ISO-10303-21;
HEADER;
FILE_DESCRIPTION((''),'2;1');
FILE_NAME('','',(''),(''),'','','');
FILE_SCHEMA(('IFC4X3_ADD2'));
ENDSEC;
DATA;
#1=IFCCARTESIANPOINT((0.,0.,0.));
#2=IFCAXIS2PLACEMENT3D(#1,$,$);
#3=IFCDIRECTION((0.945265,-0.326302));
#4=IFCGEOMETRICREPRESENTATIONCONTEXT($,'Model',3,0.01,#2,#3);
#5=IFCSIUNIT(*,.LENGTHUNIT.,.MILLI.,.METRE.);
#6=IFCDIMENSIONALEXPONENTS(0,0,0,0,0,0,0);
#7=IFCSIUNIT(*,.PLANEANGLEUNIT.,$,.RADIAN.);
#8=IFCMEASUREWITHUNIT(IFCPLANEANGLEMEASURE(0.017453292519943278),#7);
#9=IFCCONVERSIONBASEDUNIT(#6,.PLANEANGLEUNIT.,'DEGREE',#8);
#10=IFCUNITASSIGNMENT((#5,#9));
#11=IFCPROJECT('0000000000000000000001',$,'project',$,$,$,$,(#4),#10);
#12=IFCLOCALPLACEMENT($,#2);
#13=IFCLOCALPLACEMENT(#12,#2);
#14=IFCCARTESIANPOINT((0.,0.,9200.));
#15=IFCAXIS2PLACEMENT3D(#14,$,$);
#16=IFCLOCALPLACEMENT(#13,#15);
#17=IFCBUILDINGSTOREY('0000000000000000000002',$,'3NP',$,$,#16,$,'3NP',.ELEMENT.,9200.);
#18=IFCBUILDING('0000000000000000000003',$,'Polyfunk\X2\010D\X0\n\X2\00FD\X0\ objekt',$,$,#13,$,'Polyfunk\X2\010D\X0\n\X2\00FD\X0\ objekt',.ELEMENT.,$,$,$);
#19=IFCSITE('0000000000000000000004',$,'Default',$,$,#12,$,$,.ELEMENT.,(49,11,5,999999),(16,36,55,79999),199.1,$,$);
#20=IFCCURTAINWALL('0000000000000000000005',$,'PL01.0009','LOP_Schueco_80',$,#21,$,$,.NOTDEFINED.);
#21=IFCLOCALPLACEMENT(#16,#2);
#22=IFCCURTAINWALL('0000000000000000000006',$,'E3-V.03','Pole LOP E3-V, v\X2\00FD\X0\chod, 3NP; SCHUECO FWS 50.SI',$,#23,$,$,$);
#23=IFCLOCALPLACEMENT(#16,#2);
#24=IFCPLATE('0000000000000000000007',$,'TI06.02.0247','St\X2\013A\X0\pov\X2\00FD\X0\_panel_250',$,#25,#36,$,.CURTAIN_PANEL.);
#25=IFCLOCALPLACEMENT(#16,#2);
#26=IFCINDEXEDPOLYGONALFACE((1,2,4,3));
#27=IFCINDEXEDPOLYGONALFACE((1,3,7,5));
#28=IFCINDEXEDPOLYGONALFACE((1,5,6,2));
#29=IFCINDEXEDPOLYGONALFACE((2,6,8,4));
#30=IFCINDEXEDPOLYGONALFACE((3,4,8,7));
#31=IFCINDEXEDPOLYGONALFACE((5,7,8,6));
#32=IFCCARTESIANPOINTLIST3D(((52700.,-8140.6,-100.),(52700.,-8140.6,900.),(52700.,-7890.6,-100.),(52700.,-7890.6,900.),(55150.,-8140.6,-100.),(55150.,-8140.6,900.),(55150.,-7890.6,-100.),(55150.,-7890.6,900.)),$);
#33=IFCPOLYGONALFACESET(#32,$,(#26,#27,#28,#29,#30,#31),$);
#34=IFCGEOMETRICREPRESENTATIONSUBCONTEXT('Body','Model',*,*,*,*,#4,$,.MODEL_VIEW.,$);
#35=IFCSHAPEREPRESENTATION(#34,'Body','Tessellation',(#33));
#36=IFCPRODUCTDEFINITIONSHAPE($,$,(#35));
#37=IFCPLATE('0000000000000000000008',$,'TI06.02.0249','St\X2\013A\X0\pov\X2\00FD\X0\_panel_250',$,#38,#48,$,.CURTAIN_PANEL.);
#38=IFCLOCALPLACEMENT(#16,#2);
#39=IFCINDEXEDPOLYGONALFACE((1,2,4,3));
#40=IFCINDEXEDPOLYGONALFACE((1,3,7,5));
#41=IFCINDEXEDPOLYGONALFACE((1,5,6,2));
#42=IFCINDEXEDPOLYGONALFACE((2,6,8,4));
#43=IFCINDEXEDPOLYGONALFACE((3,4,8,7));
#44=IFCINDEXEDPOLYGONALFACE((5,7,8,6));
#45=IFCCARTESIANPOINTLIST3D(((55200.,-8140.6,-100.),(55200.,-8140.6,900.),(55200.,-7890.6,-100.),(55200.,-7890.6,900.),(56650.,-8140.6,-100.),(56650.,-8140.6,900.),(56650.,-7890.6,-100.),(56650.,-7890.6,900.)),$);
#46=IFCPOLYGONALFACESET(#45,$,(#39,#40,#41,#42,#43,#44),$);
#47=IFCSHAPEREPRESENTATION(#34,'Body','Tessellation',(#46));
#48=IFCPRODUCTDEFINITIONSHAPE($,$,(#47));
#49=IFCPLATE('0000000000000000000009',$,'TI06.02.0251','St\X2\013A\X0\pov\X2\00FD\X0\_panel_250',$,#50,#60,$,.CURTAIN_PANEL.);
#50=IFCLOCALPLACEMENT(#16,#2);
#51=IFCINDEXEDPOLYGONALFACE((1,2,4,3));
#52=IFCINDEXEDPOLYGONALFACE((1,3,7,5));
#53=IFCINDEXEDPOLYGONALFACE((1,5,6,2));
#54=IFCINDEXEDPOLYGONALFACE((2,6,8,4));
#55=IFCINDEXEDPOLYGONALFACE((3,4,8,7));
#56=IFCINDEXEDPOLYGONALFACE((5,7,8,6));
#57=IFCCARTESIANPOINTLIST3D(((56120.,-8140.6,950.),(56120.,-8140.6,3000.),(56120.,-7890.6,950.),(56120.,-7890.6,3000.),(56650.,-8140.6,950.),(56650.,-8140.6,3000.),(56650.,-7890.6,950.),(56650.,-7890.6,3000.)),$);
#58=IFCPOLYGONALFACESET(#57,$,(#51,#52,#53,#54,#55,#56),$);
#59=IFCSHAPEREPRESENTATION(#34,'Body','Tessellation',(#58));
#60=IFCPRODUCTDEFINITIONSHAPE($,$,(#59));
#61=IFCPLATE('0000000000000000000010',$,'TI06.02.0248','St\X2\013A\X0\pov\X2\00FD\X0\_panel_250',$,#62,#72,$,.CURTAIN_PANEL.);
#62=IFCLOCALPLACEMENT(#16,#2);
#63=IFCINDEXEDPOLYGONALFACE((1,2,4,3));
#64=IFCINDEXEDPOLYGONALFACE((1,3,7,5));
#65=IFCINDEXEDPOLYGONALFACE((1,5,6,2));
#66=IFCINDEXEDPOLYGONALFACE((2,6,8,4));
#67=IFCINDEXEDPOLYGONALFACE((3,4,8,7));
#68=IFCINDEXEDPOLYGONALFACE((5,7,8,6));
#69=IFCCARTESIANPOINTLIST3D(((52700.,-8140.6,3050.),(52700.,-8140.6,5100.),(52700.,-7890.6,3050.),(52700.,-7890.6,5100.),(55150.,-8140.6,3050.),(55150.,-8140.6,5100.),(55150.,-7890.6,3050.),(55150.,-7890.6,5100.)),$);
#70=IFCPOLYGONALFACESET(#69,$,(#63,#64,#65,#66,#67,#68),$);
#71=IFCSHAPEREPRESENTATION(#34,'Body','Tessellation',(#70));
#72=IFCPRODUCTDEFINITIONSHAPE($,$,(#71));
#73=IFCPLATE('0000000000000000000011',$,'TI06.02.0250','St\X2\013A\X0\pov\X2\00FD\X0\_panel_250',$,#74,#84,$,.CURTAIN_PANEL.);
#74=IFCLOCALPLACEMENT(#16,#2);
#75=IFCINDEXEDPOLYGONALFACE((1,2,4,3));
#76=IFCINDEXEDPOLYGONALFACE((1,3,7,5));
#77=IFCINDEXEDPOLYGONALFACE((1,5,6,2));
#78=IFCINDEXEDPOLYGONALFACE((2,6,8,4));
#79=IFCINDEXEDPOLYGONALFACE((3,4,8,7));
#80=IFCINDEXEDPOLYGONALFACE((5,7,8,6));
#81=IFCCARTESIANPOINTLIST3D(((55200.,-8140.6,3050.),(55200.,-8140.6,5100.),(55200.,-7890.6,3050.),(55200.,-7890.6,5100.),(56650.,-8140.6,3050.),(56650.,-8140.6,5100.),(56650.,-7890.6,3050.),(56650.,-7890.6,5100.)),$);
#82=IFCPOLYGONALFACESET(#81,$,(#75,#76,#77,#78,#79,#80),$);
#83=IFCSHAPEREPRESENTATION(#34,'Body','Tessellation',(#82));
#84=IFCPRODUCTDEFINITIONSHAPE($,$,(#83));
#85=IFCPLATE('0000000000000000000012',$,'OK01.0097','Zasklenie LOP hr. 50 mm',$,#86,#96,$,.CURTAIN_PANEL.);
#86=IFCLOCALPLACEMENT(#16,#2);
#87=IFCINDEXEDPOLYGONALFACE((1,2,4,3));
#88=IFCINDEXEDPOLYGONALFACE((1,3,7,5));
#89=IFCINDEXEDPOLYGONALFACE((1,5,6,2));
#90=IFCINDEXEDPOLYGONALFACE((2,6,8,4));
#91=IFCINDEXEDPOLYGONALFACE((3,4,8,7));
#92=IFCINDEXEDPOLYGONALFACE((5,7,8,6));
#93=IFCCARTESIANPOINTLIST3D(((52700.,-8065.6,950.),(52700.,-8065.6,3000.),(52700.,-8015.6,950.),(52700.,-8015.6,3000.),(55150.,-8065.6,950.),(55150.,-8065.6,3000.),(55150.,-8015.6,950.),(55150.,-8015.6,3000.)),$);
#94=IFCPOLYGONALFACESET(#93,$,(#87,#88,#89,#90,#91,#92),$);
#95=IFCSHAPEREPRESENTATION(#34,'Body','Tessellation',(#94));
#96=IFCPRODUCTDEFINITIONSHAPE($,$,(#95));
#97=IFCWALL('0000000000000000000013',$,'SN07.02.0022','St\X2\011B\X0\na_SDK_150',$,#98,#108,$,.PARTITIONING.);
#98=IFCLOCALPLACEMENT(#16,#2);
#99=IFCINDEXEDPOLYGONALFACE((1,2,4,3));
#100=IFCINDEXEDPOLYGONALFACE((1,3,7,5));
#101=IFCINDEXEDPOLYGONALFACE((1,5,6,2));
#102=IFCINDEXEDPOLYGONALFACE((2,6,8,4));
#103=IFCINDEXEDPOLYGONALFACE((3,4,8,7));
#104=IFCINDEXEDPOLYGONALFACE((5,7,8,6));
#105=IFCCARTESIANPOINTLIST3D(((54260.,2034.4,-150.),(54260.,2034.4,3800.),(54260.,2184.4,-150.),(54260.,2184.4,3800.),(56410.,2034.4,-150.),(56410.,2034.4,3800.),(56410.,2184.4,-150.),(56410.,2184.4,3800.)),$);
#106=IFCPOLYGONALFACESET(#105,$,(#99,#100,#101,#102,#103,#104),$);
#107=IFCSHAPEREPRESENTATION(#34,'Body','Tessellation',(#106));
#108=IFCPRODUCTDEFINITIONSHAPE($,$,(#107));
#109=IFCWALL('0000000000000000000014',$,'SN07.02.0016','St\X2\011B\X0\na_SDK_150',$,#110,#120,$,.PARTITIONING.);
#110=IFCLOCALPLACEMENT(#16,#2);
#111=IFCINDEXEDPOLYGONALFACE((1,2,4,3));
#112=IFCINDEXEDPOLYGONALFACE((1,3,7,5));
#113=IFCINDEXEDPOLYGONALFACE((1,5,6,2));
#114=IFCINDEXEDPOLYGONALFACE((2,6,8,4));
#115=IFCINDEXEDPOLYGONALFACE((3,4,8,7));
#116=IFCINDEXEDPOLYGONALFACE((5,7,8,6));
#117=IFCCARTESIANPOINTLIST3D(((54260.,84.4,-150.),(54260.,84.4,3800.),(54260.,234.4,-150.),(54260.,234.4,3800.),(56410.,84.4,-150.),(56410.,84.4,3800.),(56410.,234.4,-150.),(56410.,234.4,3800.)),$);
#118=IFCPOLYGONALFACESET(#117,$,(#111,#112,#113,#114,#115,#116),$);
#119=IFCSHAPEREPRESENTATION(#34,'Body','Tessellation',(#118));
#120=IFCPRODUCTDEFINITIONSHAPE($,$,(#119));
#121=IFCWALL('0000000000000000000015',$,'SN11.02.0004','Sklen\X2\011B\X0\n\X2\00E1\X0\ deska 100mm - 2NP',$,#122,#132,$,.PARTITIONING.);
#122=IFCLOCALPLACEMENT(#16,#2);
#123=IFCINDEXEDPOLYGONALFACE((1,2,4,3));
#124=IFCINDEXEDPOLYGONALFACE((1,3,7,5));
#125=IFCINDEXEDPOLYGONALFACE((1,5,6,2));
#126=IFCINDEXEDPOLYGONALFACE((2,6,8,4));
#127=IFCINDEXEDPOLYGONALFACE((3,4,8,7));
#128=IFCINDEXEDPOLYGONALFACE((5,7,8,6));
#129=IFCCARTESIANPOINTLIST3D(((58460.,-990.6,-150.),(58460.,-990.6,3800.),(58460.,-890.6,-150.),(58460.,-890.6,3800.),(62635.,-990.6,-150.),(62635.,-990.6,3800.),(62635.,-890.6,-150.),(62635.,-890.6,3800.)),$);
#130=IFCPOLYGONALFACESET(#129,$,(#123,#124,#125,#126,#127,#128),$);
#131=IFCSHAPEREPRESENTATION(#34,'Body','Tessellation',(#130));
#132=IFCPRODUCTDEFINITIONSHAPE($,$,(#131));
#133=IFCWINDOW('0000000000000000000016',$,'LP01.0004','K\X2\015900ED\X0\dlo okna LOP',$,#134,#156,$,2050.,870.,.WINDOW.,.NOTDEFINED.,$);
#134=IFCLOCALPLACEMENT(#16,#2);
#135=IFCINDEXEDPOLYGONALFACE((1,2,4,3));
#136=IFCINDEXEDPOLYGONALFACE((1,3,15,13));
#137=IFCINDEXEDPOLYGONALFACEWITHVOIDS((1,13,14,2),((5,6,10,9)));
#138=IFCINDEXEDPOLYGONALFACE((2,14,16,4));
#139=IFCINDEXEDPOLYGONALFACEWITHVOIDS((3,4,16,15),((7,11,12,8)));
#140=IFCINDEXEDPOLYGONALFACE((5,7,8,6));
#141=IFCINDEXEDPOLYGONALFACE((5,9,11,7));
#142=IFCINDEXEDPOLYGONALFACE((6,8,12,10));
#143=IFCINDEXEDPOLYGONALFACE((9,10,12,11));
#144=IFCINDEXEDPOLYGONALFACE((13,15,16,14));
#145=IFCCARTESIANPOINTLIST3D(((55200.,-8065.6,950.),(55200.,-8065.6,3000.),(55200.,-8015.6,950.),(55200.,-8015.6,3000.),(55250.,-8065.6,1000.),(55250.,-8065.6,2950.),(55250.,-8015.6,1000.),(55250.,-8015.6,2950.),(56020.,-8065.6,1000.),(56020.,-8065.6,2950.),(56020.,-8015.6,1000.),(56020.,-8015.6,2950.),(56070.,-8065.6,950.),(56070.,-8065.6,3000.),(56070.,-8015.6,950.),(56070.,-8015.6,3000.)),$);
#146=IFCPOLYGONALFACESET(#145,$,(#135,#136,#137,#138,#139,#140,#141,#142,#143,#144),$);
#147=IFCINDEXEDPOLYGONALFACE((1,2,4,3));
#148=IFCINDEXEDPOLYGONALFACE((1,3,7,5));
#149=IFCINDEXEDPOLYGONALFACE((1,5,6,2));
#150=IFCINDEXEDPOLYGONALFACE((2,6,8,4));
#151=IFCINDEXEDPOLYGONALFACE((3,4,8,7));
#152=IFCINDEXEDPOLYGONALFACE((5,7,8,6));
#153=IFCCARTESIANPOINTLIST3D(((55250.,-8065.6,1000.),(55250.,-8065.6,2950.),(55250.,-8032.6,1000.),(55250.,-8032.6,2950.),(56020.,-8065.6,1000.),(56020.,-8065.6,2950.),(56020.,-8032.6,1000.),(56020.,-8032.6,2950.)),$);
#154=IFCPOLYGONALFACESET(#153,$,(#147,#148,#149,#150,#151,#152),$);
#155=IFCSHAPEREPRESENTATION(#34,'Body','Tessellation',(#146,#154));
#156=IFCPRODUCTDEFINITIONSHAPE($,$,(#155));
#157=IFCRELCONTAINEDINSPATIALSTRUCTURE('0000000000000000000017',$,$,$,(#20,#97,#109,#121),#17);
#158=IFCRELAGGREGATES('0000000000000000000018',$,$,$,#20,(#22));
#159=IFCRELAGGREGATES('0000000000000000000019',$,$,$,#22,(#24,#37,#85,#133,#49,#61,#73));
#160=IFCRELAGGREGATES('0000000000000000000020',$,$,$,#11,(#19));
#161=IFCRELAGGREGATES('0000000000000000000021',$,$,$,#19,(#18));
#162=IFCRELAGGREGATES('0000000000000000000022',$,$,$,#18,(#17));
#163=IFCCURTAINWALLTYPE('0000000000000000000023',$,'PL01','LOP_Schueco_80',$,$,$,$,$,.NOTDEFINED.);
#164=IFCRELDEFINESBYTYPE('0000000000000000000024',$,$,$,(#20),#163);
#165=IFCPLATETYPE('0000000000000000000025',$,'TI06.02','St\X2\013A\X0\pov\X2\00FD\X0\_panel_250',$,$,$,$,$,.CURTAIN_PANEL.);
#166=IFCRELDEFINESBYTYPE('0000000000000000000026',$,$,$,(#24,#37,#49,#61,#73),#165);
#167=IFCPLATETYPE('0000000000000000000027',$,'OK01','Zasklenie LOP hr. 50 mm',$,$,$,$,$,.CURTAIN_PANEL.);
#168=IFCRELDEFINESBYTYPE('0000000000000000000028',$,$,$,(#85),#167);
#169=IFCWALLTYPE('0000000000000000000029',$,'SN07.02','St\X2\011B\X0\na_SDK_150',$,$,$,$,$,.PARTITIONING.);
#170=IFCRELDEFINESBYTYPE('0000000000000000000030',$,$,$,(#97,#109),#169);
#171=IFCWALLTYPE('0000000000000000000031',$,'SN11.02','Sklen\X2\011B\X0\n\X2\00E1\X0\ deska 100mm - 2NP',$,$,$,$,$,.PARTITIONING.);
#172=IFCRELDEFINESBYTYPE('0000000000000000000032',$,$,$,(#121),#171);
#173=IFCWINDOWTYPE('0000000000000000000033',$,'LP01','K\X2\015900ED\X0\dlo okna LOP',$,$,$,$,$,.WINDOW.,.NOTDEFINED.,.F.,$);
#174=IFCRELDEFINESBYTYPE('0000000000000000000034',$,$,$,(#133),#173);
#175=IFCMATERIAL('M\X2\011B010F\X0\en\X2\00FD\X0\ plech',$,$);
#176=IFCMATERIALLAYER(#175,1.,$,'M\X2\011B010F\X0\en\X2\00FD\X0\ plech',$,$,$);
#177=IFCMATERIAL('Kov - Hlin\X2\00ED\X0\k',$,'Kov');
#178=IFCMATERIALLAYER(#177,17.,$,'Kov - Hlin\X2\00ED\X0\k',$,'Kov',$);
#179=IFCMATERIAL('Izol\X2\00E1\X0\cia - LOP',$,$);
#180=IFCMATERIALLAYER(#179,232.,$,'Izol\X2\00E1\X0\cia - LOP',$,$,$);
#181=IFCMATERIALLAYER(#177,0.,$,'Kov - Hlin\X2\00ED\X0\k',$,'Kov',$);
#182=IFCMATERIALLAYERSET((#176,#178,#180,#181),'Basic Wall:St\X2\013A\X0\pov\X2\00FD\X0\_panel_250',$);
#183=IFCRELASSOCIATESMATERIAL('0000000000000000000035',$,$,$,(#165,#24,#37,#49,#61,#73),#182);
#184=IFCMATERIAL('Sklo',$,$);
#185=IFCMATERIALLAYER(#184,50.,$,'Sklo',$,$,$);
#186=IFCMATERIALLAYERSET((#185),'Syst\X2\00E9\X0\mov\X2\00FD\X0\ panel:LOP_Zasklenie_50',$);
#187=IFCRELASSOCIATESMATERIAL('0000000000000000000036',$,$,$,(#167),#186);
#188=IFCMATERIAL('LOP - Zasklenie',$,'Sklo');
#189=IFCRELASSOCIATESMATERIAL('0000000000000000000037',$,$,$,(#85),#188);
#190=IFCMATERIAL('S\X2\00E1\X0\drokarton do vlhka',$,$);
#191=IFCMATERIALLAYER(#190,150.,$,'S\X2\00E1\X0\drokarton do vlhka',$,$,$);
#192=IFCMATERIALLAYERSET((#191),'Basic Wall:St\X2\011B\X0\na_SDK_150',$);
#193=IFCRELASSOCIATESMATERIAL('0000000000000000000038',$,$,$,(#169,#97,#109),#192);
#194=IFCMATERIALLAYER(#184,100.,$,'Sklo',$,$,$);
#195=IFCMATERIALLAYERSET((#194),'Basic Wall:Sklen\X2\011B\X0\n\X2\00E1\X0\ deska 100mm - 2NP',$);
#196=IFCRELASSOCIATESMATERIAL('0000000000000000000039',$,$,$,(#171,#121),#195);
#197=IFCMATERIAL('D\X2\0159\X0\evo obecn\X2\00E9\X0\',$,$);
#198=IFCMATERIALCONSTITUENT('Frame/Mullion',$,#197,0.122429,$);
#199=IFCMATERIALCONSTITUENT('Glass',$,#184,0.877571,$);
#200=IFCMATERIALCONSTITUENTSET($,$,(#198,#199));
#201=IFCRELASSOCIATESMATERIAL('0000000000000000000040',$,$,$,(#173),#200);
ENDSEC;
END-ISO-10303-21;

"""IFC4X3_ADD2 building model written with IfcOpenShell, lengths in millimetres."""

from ifc_helpers import new_model, entity, si_unit, converted_unit, direction, frame, frame_2d, origin, origin_2d_with_axis, place, context, subcontext, project, spatial, polyline, rectangle, outline, extrude, clip, bounded_halfspace, source, transform, mapped, material, layer, layer_set, layer_usage, constituent, constituent_set, type_object, type_shapes, element, aggregate, save


model = new_model("IFC4X3_ADD2")

# Units and contexts
model_context = context("Model", 3, precision=0.01, world=origin(), true_north=direction((0.945265, -0.326302)))
body_context = subcontext(model_context, "Body", "Model", "MODEL_VIEW")
ifc_project = project(units=[si_unit("LENGTHUNIT", "METRE", prefix="MILLI"), converted_unit("PLANEANGLEUNIT", "DEGREE", entity("IfcPlaneAngleMeasure", 0.017453292519943278), si_unit("PLANEANGLEUNIT", "RADIAN"), dimensions=[0, 0, 0, 0, 0, 0, 0])], contexts=[model_context])

# Site, building, storey
site_placement = place(None, origin())
site = spatial("IfcSite", under=ifc_project, at=site_placement, Name="Default", CompositionType="ELEMENT", RefLatitude=(49, 11, 5, 999999), RefLongitude=(16, 36, 55, 79999), RefElevation=199.1)
building_placement = place(site_placement, origin())
building = spatial("IfcBuilding", under=site, at=building_placement, Name="Polyfunkčný objekt", LongName="Polyfunkčný objekt", CompositionType="ELEMENT")
storey_placement = place(building_placement, frame((0.0, 0.0, 9200.0)))
storey = spatial("IfcBuildingStorey", under=building, at=storey_placement, Name="3NP", LongName="3NP", CompositionType="ELEMENT", Elevation=9200.0)

# Curtain walls, plates
curtain_wall_type = type_object("IfcCurtainWallType", Name="PL01", Description="LOP_Schueco_80", PredefinedType="NOTDEFINED")
curtain_wall_1_placement = place(storey_placement, frame((0.0, 0.0, -9200.0)))
curtain_wall_1 = element("IfcCurtainWall", 1, at=curtain_wall_1_placement, inside=storey, type_object=curtain_wall_type, Name="PL01.0009", Description="LOP_Schueco_80", PredefinedType="NOTDEFINED")
curtain_wall_2 = element("IfcCurtainWall", 2, Name="E3-V.03", Description="Pole LOP E3-V, východ, 3NP; SCHUECO FWS 50.SI")
aggregate(curtain_wall_1, [curtain_wall_2])
ifc_material_1 = material(Name="Měďený plech")
ifc_layer_1 = layer(ifc_material_1, 1.0, Name="Měďený plech")
ifc_material_2 = material(Name="Kov - Hliník", Category="Kov")
ifc_layer_2 = layer(ifc_material_2, 17.0, Name="Kov - Hliník", Category="Kov")
ifc_material_3 = material(Name="Izolácia - LOP")
ifc_layer_3 = layer(ifc_material_3, 232.0, Name="Izolácia - LOP")
ifc_layer_4 = layer(ifc_material_2, 0.0, Name="Kov - Hliník", Category="Kov")
ifc_layer_set_1 = layer_set([ifc_layer_1, ifc_layer_2, ifc_layer_3, ifc_layer_4], Name="Basic Wall:Stĺpový_panel_250")
ifc_layer_usage_1 = layer_usage(ifc_layer_set_1, "AXIS2", "POSITIVE", -125.0)
plate_type_1 = type_object("IfcPlateType", Name="TI06.02", Description="Stĺpový_panel_250", PredefinedType="CURTAIN_PANEL", material=ifc_layer_set_1)
plate_1_placement = place(storey_placement, frame((52700.0, -8015.6, -100.0)))
plate_1 = element("IfcPlate", 3, at=plate_1_placement, type_object=plate_type_1, material=ifc_layer_usage_1, Name="TI06.02.0247", Description="Stĺpový_panel_250", PredefinedType="CURTAIN_PANEL", context=body_context, shape_type="SweptSolid", body=[
    extrude(rectangle(XDim=250.0, YDim=2450.0, at=frame_2d((0.0, 0.0), x_axis=(1.0, 0.0))), frame((1225.0, 0.0, 0.0), z_axis=(0.0, 0.0, 1.0), x_axis=(0.0, 1.0, 0.0)), (0.0, 0.0, 1.0), 1000.0),
])
ifc_layer_usage_2 = layer_usage(ifc_layer_set_1, "AXIS2", "POSITIVE", -125.0)
plate_2_placement = place(storey_placement, frame((55200.0, -8015.6, -100.0)))
plate_2 = element("IfcPlate", 4, at=plate_2_placement, type_object=plate_type_1, material=ifc_layer_usage_2, Name="TI06.02.0249", Description="Stĺpový_panel_250", PredefinedType="CURTAIN_PANEL", context=body_context, shape_type="SweptSolid", body=[
    extrude(rectangle(XDim=250.0, YDim=1450.0, at=frame_2d((0.0, 0.0), x_axis=(1.0, 0.0))), frame((725.0, 0.0, 0.0), z_axis=(0.0, 0.0, 1.0), x_axis=(0.0, 1.0, 0.0)), (0.0, 0.0, 1.0), 1000.0),
])
ifc_layer_usage_3 = layer_usage(ifc_layer_set_1, "AXIS2", "POSITIVE", -125.0)
plate_3_placement = place(storey_placement, frame((56120.0, -8015.6, 950.0)))
plate_3 = element("IfcPlate", 5, at=plate_3_placement, type_object=plate_type_1, material=ifc_layer_usage_3, Name="TI06.02.0251", Description="Stĺpový_panel_250", PredefinedType="CURTAIN_PANEL", context=body_context, shape_type="SweptSolid", body=[
    extrude(rectangle(XDim=250.0, YDim=530.0, at=origin_2d_with_axis()), frame((265.0, 0.0, 0.0), z_axis=(0.0, 0.0, 1.0), x_axis=(0.0, 1.0, 0.0)), (0.0, 0.0, 1.0), 2050.0),
])
ifc_layer_usage_4 = layer_usage(ifc_layer_set_1, "AXIS2", "POSITIVE", -125.0)
plate_4_placement = place(storey_placement, frame((52700.0, -8015.6, 3050.0)))
plate_4 = element("IfcPlate", 6, at=plate_4_placement, type_object=plate_type_1, material=ifc_layer_usage_4, Name="TI06.02.0248", Description="Stĺpový_panel_250", PredefinedType="CURTAIN_PANEL", context=body_context, shape_type="SweptSolid", body=[
    extrude(rectangle(XDim=250.0, YDim=2450.0, at=frame_2d((0.0, 0.0), x_axis=(1.0, 0.0))), frame((1225.0, 0.0, 0.0), z_axis=(0.0, 0.0, 1.0), x_axis=(0.0, 1.0, 0.0)), (0.0, 0.0, 1.0), 2050.0),
])
ifc_layer_usage_5 = layer_usage(ifc_layer_set_1, "AXIS2", "POSITIVE", -125.0)
plate_5_placement = place(storey_placement, frame((55200.0, -8015.6, 3050.0)))
plate_5 = element("IfcPlate", 7, at=plate_5_placement, type_object=plate_type_1, material=ifc_layer_usage_5, Name="TI06.02.0250", Description="Stĺpový_panel_250", PredefinedType="CURTAIN_PANEL", context=body_context, shape_type="SweptSolid", body=[
    extrude(rectangle(XDim=250.0, YDim=1450.0, at=frame_2d((0.0, 0.0), x_axis=(1.0, 0.0))), frame((725.0, 0.0, 0.0), z_axis=(0.0, 0.0, 1.0), x_axis=(0.0, 1.0, 0.0)), (0.0, 0.0, 1.0), 2050.0),
])
ifc_material_4 = material(Name="LOP - Zasklenie", Category="Sklo")
ifc_material_5 = material(Name="Sklo")
ifc_layer_5 = layer(ifc_material_5, 50.0, Name="Sklo")
ifc_layer_set_2 = layer_set([ifc_layer_5], Name="Systémový panel:LOP_Zasklenie_50")
plate_type_2 = type_object("IfcPlateType", Name="OK01", Description="Zasklenie LOP hr. 50 mm", PredefinedType="CURTAIN_PANEL", material=ifc_layer_set_2)
shared_shape_1 = source(origin(), body_context, "Body", "SweptSolid", [
    extrude(rectangle(XDim=50.0, YDim=2450.0, at=origin_2d_with_axis()), frame((0.0, -25.0, 0.0), z_axis=(0.0, 0.0, 1.0), x_axis=(0.0, 1.0, 0.0)), (0.0, 0.0, 1.0), 2050.0),
])
type_shapes(plate_type_2, [shared_shape_1])
plate_6_placement = place(curtain_wall_1_placement, frame((53925.0, -8015.6, 10150.0)))
plate_6 = element("IfcPlate", 8, at=plate_6_placement, type_object=plate_type_2, material=ifc_material_4, Name="OK01.0097", Description="Zasklenie LOP hr. 50 mm", PredefinedType="CURTAIN_PANEL", context=body_context, shape_type="MappedRepresentation", body=[
    mapped(shared_shape_1, transform((0.0, 0.0, 0.0), scale=1.0)),
])

# Walls
ifc_material_6 = material(Name="Sádrokarton do vlhka")
ifc_layer_6 = layer(ifc_material_6, 150.0, Name="Sádrokarton do vlhka")
ifc_layer_set_3 = layer_set([ifc_layer_6], Name="Basic Wall:Stěna_SDK_150")
wall_type_1 = type_object("IfcWallType", Name="SN07.02", Description="Stěna_SDK_150", PredefinedType="PARTITIONING", material=ifc_layer_set_3)
placement = place(building_placement, frame((0.0, 0.0, 5000.0)))
wall_1_placement = place(placement, frame((56410.0, 2109.4, 4050.0), z_axis=(0.0, 0.0, 1.0), x_axis=(-1.0, 0.0, 0.0)))
element("IfcWall", 9, at=wall_1_placement, inside=storey, type_object=wall_type_1, material=ifc_layer_set_3, Name="SN07.02.0022", Description="Stěna_SDK_150", PredefinedType="PARTITIONING", context=body_context, shape_type="Clipping", body=[
    clip(clip(extrude(rectangle(XDim=2150.0, YDim=150.0, at=frame_2d((1075.0, 0.0), x_axis=(-1.0, 0.0))), origin(), (0.0, 0.0, 1.0), 3950.0), bounded_halfspace(frame((2150.0, -75.0, 0.0)), True, frame((2150.0, -75.0, 0.0)), polyline([(0.0, 0.0), (0.0, 150.0), (-2150.0, 150.0), (-2150.0, 0.0), (0.0, 0.0)]))), bounded_halfspace(frame((0.0, -75.0, 3950.0), z_axis=(0.0, 0.0, -1.0), x_axis=(-1.0, 0.0, 0.0)), True, frame((0.0, -75.0, 3950.0)), polyline([(0.0, 0.0), (2150.0, 0.0), (2150.0, 150.0), (0.0, 150.0), (0.0, 0.0)]))),
])
wall_2_placement = place(placement, frame((56410.0, 159.4, 4050.0), z_axis=(0.0, 0.0, 1.0), x_axis=(-1.0, 0.0, 0.0)))
element("IfcWall", 10, at=wall_2_placement, inside=storey, type_object=wall_type_1, material=ifc_layer_set_3, Name="SN07.02.0016", Description="Stěna_SDK_150", PredefinedType="PARTITIONING", context=body_context, shape_type="Clipping", body=[
    clip(clip(extrude(rectangle(XDim=2150.0, YDim=150.0, at=frame_2d((1075.0, 0.0), x_axis=(-1.0, 0.0))), origin(), (0.0, 0.0, 1.0), 3950.0), bounded_halfspace(frame((2150.0, -75.0, 0.0)), True, frame((2150.0, -75.0, 0.0)), polyline([(0.0, 0.0), (0.0, 150.0), (-2150.0, 150.0), (-2150.0, 0.0), (0.0, 0.0)]))), bounded_halfspace(frame((0.0, -75.0, 3950.0), z_axis=(0.0, 0.0, -1.0), x_axis=(-1.0, 0.0, 0.0)), True, frame((0.0, -75.0, 3950.0)), polyline([(0.0, 0.0), (2150.0, 0.0), (2150.0, 150.0), (0.0, 150.0), (0.0, 0.0)]))),
])
ifc_layer_7 = layer(ifc_material_5, 100.0, Name="Sklo")
ifc_layer_set_4 = layer_set([ifc_layer_7], Name="Basic Wall:Skleněná deska 100mm - 2NP")
wall_type_2 = type_object("IfcWallType", Name="SN11.02", Description="Skleněná deska 100mm - 2NP", PredefinedType="PARTITIONING", material=ifc_layer_set_4)
wall_3_placement = place(placement, frame((58460.0, -940.6, 4050.0)))
element("IfcWall", 11, at=wall_3_placement, inside=storey, type_object=wall_type_2, material=ifc_layer_set_4, Name="SN11.02.0004", Description="Skleněná deska 100mm - 2NP", PredefinedType="PARTITIONING", context=body_context, shape_type="Clipping", body=[
    clip(clip(extrude(rectangle(XDim=4175.0, YDim=100.0, at=frame_2d((2087.5, 0.0), x_axis=(-1.0, 0.0))), origin(), (0.0, 0.0, 1.0), 3950.0), bounded_halfspace(frame((4175.0, -50.0, 0.0), z_axis=(0.0, 0.0, 1.0), x_axis=(-1.0, 0.0, 0.0)), True, frame((4175.0, -50.0, 0.0)), polyline([(0.0, 0.0), (0.0, 100.0), (-4075.0, 100.0), (-4175.0, 100.0), (-4175.0, 0.0), (0.0, 0.0)]))), bounded_halfspace(frame((0.0, -50.0, 3950.0), z_axis=(0.0, 0.0, -1.0), x_axis=(1.0, 0.0, 0.0)), True, frame((0.0, -50.0, 3950.0)), polyline([(0.0, 0.0), (4175.0, 0.0), (4175.0, 100.0), (100.0, 100.0), (0.0, 100.0), (0.0, 0.0)]))),
])

# Window
ifc_material_7 = material(Name="Dřevo obecné")
ifc_constituent_1 = constituent(ifc_material_7, Name="Frame/Mullion", fraction=0.122429)
ifc_constituent_2 = constituent(ifc_material_5, Name="Glass", fraction=0.877571)
ifc_constituent_set = constituent_set(constituents=[ifc_constituent_1, ifc_constituent_2])
window_type = type_object("IfcWindowType", Name="LP01", Description="Křídlo okna LOP", ParameterTakesPrecedence=False, PartitioningType="NOTDEFINED", PredefinedType="WINDOW", material=ifc_constituent_set)
shared_shape_2 = source(origin(), body_context, "Body", "SweptSolid", [
    extrude(outline(polyline([(-1025.0, -435.0), (1025.0, -435.0), (1025.0, 435.0), (-1025.0, 435.0), (-1025.0, -435.0)]), holes=[polyline([(-975.0, -385.0), (-975.0, 385.0), (975.0, 385.0), (975.0, -385.0), (-975.0, -385.0)])]), frame((0.0, 50.0, 1025.0), z_axis=(0.0, -1.0, 0.0), x_axis=(0.0, 0.0, -1.0)), (0.0, 0.0, 1.0), 50.0),
    extrude(rectangle(XDim=770.0, YDim=33.0, at=frame_2d((0.0, 0.0), x_axis=(1.0, 0.0))), frame((0.0, 33.5, 50.0), z_axis=(0.0, 0.0, 1.0), x_axis=(-1.0, 0.0, 0.0)), (0.0, 0.0, 1.0), 1950.0),
])
type_shapes(window_type, [shared_shape_2])
window_placement = place(curtain_wall_1_placement, frame((55635.0, -8015.6, 10150.0), z_axis=(0.0, 0.0, 1.0), x_axis=(-1.0, 0.0, 0.0)))
window = element("IfcWindow", 12, at=window_placement, type_object=window_type, Name="LP01.0004", Description="Křídlo okna LOP", OverallHeight=2050.0, OverallWidth=870.0, PartitioningType="NOTDEFINED", PredefinedType="WINDOW", context=body_context, shape_type="MappedRepresentation", body=[
    mapped(shared_shape_2, transform((0.0, 0.0, 0.0), scale=1.0)),
])
aggregate(curtain_wall_2, [plate_1, plate_2, plate_6, window, plate_3, plate_4, plate_5])

save(model, "model.ifc")
